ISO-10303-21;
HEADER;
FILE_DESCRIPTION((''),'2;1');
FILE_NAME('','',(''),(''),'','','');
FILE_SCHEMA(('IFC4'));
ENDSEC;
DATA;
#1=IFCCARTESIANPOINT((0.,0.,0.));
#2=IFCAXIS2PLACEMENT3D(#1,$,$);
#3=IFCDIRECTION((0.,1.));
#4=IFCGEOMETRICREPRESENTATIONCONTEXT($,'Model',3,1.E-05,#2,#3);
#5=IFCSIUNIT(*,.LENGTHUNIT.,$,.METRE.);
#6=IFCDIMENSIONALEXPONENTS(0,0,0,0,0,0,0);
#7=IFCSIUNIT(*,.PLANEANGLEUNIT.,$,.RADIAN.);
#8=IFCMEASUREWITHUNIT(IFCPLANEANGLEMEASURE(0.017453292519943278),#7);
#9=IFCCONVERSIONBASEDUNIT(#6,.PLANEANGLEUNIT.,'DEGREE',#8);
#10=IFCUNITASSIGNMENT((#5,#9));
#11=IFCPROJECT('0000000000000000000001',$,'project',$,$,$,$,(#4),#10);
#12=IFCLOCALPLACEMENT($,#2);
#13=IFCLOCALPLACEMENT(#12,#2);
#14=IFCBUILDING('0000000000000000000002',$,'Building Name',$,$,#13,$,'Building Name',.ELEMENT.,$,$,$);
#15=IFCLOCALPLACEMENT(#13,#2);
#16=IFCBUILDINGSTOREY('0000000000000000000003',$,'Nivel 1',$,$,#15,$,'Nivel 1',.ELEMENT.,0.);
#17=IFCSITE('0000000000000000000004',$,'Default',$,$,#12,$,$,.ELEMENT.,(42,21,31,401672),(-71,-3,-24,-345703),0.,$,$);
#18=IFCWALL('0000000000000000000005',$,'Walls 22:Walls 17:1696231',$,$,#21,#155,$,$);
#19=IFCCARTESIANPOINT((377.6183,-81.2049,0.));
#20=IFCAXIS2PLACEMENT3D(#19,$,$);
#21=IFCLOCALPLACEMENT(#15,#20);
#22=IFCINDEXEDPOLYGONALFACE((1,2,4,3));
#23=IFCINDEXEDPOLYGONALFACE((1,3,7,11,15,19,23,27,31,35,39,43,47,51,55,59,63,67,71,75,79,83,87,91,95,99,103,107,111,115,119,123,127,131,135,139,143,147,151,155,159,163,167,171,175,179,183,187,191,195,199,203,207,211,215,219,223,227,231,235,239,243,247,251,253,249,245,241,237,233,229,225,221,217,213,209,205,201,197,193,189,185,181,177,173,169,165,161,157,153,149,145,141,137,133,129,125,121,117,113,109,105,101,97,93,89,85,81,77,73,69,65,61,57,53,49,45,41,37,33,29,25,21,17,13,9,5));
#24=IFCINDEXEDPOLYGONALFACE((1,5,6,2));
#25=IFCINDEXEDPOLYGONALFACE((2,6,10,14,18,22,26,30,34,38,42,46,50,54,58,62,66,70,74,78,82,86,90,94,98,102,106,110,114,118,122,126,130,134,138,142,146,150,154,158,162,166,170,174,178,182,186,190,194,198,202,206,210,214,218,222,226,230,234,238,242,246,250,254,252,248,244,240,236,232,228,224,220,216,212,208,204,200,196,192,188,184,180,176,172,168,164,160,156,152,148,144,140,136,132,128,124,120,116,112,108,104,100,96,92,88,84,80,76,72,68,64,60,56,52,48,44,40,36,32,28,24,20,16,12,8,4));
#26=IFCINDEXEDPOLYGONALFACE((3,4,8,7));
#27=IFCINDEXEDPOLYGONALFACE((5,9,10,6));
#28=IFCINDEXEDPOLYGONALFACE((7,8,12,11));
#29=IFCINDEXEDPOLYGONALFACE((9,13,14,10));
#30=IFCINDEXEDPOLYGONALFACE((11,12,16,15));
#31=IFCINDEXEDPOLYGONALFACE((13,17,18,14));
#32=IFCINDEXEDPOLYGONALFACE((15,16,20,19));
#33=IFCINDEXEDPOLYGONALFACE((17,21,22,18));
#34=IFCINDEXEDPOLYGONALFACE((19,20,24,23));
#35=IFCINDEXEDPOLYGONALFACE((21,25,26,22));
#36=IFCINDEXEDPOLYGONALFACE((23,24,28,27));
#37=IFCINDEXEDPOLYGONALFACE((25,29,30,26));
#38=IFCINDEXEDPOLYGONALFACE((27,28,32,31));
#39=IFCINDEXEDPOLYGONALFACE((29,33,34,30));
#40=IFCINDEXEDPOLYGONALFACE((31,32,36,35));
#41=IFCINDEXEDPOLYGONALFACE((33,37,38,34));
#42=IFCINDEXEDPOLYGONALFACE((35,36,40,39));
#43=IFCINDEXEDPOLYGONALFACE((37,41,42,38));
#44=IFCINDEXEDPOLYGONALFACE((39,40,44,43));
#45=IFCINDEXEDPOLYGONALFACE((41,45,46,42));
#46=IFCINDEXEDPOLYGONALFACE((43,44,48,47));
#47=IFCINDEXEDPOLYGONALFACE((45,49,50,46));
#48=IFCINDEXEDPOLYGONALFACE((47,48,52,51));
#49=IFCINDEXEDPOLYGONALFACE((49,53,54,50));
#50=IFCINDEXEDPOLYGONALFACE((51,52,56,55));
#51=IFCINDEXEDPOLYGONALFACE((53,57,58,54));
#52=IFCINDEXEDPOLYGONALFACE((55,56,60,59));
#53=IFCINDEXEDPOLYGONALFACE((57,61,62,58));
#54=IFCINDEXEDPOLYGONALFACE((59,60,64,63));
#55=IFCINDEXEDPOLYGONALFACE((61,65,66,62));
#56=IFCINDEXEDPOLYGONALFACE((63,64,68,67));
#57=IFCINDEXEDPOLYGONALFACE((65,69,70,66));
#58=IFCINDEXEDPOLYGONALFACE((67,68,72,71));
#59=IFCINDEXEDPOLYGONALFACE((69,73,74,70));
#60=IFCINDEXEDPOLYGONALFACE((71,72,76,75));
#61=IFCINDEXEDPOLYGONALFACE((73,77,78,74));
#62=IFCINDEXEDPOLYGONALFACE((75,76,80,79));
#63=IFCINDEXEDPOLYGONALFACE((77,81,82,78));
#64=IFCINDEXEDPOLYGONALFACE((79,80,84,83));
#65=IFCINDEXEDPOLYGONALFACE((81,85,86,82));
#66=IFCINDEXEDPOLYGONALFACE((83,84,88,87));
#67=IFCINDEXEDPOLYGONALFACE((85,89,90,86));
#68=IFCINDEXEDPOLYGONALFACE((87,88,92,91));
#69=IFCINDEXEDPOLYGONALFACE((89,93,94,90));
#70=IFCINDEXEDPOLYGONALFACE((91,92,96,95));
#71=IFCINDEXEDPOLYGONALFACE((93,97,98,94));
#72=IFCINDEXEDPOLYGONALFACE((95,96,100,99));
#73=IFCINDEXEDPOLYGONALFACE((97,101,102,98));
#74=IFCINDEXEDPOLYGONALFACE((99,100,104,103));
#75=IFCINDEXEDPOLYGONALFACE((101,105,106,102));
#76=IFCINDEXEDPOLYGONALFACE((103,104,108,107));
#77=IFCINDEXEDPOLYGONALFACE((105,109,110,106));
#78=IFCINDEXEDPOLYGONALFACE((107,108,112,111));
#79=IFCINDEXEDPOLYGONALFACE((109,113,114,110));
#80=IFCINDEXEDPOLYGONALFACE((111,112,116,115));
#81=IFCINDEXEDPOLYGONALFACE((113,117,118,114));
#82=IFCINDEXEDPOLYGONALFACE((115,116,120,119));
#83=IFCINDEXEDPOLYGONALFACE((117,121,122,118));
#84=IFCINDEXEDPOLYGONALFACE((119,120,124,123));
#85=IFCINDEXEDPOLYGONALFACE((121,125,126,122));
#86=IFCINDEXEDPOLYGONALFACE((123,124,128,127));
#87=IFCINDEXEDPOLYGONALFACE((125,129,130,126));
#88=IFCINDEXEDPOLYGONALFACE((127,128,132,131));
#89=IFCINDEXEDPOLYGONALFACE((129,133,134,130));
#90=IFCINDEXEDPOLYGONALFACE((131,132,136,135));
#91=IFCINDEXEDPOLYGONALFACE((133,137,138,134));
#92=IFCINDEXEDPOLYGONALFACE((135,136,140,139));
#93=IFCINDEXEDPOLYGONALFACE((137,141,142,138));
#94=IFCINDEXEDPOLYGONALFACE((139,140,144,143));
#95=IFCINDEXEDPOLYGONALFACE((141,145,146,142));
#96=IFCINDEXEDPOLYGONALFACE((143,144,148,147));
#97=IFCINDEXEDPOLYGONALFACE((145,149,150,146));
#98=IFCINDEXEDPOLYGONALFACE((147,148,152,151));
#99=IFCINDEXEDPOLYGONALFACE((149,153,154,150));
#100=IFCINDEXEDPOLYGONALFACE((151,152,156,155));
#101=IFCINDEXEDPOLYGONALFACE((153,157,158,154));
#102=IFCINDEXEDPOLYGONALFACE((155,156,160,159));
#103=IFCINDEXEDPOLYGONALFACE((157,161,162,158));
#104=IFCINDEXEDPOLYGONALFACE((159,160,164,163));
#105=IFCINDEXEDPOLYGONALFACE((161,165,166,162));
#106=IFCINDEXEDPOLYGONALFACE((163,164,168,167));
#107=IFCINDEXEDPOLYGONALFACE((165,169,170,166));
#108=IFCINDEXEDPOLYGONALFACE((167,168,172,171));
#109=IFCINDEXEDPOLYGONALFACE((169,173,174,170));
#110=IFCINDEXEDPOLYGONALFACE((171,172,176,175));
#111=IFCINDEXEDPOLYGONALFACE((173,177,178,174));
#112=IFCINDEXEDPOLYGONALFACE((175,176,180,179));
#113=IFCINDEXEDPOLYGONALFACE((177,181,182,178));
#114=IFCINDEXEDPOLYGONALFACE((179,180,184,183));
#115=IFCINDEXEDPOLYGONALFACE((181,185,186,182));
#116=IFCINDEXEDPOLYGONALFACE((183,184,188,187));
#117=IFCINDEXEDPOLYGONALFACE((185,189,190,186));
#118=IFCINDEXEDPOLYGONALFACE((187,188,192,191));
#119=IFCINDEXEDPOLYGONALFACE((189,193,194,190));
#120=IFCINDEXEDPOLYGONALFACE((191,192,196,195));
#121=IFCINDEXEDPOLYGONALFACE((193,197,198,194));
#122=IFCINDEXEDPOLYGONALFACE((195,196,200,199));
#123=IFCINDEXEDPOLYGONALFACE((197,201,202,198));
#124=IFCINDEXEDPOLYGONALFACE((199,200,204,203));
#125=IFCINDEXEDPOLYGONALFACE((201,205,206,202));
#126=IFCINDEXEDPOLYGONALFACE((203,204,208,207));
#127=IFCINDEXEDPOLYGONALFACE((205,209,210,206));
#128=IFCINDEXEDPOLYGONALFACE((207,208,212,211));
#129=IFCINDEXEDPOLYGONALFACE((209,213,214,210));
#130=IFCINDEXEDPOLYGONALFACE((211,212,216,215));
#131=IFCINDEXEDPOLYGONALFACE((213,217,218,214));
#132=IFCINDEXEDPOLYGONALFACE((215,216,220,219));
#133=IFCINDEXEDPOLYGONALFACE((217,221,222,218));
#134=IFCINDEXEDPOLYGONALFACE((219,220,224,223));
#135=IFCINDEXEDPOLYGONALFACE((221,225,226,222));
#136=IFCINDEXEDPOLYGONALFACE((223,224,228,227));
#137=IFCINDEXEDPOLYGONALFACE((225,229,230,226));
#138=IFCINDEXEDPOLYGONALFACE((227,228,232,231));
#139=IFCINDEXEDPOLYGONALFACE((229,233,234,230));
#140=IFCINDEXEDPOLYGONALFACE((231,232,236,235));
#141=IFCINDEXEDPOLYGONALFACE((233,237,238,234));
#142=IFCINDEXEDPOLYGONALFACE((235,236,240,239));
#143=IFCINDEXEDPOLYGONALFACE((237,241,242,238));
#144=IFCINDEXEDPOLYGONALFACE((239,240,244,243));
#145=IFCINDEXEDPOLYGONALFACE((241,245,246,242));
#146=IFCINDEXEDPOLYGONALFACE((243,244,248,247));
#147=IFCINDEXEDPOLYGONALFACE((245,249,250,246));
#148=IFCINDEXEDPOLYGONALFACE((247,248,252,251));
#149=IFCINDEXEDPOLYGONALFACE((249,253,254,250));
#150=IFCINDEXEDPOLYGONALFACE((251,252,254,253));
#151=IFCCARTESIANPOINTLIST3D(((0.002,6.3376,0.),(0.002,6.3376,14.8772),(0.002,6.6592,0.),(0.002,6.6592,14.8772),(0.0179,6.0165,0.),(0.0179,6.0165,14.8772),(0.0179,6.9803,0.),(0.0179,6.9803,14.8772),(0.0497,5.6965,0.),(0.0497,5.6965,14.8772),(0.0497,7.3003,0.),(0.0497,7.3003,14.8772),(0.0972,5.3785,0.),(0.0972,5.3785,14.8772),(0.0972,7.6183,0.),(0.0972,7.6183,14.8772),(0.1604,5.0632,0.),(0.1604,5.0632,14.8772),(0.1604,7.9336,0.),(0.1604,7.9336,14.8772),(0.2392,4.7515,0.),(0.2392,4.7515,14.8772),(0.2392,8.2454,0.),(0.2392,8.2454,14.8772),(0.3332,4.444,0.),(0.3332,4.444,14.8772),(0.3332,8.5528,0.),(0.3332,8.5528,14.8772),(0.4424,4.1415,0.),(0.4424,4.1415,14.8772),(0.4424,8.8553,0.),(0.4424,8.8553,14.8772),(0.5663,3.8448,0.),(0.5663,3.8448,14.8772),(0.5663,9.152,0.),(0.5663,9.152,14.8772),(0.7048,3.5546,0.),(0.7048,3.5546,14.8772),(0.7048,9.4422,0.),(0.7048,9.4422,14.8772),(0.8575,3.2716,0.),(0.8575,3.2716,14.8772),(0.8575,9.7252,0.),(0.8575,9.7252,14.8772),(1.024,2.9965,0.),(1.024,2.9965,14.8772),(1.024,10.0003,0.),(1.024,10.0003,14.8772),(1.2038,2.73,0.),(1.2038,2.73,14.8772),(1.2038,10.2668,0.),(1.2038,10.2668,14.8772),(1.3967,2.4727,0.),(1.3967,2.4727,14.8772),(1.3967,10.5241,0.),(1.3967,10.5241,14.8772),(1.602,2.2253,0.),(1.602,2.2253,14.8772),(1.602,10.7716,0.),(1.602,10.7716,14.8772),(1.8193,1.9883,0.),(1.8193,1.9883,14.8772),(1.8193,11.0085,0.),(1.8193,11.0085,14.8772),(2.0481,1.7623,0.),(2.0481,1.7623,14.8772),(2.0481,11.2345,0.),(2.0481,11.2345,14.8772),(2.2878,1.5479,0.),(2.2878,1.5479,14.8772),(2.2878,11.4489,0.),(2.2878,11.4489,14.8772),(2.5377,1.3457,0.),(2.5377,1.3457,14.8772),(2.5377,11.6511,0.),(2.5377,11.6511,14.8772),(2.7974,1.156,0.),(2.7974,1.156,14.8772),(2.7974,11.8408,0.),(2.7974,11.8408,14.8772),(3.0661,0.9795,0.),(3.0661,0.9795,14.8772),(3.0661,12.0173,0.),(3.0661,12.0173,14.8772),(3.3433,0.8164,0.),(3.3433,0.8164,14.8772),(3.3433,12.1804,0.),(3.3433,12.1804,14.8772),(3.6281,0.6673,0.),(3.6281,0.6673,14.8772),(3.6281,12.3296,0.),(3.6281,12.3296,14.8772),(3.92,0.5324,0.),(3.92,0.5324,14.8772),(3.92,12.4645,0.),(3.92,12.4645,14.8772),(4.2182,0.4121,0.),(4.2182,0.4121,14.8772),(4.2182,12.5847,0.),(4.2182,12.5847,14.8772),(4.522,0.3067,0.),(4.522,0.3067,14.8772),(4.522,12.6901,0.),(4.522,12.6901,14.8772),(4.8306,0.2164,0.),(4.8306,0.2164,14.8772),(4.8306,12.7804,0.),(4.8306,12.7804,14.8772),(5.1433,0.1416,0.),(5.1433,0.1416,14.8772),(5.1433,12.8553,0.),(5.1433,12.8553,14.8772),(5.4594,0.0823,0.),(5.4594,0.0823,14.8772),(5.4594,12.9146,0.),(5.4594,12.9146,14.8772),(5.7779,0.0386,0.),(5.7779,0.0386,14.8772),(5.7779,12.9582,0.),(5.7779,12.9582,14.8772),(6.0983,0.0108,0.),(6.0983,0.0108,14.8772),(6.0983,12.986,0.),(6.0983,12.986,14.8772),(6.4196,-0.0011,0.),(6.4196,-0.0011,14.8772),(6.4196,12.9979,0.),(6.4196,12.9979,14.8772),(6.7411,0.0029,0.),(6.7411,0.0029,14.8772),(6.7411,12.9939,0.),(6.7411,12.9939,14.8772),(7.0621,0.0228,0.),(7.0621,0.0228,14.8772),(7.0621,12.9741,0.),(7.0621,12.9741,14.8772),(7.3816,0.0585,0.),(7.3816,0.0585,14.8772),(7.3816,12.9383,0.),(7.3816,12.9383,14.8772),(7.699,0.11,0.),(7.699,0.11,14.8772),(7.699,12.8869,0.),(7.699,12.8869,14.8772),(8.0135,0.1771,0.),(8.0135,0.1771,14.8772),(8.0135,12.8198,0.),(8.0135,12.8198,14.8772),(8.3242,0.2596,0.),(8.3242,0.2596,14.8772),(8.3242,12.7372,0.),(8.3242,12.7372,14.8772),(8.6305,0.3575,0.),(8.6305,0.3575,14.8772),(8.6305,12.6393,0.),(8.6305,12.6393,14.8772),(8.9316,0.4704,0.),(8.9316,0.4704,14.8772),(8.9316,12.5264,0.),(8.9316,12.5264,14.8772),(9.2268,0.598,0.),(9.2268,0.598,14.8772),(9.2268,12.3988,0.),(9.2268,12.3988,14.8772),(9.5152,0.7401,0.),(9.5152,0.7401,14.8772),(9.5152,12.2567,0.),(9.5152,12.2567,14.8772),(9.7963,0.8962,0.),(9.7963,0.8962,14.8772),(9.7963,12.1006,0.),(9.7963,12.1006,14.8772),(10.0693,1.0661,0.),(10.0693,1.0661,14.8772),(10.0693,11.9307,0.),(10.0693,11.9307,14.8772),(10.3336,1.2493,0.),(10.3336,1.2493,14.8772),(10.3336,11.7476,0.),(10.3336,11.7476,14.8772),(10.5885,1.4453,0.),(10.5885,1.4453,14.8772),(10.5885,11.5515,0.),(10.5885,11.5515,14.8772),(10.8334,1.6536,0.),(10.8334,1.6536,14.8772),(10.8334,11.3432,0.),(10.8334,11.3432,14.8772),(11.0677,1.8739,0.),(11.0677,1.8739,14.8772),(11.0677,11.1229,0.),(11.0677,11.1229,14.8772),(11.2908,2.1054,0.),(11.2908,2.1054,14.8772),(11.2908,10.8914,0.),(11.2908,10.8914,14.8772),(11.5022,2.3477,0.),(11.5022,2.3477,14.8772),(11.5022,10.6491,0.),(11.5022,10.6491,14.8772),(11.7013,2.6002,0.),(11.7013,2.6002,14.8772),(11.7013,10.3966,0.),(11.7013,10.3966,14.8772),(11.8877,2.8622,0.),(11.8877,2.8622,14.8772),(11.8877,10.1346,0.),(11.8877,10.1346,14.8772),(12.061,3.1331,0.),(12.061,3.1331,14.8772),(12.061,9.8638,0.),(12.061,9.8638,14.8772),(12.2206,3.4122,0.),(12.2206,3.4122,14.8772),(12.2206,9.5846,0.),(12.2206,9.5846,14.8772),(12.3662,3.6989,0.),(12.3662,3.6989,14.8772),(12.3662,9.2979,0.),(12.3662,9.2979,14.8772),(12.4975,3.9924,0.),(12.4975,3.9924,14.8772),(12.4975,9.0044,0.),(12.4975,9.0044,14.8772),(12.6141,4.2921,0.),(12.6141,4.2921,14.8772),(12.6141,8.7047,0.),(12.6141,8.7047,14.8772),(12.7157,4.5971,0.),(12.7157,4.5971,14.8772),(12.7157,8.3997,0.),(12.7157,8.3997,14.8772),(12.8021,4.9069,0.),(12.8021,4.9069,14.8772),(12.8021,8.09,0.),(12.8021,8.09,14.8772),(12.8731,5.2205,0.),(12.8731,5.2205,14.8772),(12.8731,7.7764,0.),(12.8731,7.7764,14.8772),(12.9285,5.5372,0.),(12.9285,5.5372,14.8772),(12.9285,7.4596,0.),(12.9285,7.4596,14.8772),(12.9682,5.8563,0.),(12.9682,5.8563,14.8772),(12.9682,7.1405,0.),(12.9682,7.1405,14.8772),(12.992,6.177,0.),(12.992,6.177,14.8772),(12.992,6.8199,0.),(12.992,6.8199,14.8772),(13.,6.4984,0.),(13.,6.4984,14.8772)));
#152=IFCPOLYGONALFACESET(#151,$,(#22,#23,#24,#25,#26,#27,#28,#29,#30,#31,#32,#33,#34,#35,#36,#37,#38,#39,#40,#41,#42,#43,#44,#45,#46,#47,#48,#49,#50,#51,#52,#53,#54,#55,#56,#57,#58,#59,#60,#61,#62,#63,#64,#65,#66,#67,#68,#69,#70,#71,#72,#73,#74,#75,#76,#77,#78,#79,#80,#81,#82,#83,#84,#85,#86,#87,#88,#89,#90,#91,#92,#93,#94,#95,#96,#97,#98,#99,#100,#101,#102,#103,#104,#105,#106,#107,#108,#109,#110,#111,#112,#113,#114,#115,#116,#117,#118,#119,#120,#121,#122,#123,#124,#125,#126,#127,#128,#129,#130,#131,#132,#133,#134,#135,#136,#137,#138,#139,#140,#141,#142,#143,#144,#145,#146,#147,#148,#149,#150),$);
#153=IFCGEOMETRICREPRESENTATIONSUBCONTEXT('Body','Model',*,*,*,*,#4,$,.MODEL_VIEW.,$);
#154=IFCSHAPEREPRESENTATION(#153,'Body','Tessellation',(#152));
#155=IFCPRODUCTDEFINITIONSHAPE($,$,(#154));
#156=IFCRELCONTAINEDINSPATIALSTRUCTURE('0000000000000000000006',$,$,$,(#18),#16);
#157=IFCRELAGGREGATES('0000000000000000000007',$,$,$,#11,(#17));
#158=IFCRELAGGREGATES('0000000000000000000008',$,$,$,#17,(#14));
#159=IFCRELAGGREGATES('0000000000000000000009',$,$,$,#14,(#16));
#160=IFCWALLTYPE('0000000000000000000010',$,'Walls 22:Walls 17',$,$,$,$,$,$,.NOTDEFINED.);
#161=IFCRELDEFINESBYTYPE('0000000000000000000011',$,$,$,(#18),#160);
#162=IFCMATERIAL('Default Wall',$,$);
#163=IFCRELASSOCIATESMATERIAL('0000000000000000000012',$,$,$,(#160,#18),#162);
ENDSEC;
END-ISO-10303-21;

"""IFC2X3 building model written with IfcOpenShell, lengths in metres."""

from ifc_helpers import new_model, entity, si_unit, converted_unit, direction, frame, frame_2d, origin, place, context, subcontext, project, spatial, circle, extrude, material, type_object, element, save


model = new_model("IFC2X3")

# Units and contexts
model_context = context("Model", 3, precision=1e-05, world=origin(), true_north=direction((0.0, 1.0)))
body_context = subcontext(model_context, "Body", "Model", "MODEL_VIEW")
ifc_project = project(units=[si_unit("LENGTHUNIT", "METRE"), converted_unit("PLANEANGLEUNIT", "DEGREE", entity("IfcPlaneAngleMeasure", 0.017453292519943278), si_unit("PLANEANGLEUNIT", "RADIAN"), dimensions=[0, 0, 0, 0, 0, 0, 0])], contexts=[model_context])

# Site, building, storey
site_placement = place(None, origin())
site = spatial("IfcSite", under=ifc_project, at=site_placement, Name="Default", CompositionType="ELEMENT", RefLatitude=(42, 21, 31, 401672), RefLongitude=(-71, -3, -24, -345703), RefElevation=0.0)
building_placement = place(site_placement, origin())
building = spatial("IfcBuilding", under=site, at=building_placement, Name="Building Name", LongName="Building Name", CompositionType="ELEMENT")
storey_placement = place(building_placement, origin())
storey = spatial("IfcBuildingStorey", under=building, at=storey_placement, Name="Nivel 1", LongName="Nivel 1", CompositionType="ELEMENT", Elevation=0.0)

# Wall
ifc_material_1 = material(Name="Default Wall")
wall_type_1 = type_object("IfcWallType", Name="Walls 22:Walls 17", PredefinedType="NOTDEFINED", material=ifc_material_1)
wall_1_placement = place(storey_placement, frame((377.6183, -81.2049, 0.0)))
element("IfcWall", 1, at=wall_1_placement, inside=storey, type_object=wall_type_1, material=ifc_material_1, Name="Walls 22:Walls 17:1696231", context=body_context, shape_type="SweptSolid", body=[
    extrude(circle(Radius=6.5, at=frame_2d((0.0, 0.0), x_axis=(1.0, 0.0))), frame((6.5, 6.4984, 0.0)), (0.0, 0.0, 1.0), 14.8772),
])

save(model, "model.ifc")
